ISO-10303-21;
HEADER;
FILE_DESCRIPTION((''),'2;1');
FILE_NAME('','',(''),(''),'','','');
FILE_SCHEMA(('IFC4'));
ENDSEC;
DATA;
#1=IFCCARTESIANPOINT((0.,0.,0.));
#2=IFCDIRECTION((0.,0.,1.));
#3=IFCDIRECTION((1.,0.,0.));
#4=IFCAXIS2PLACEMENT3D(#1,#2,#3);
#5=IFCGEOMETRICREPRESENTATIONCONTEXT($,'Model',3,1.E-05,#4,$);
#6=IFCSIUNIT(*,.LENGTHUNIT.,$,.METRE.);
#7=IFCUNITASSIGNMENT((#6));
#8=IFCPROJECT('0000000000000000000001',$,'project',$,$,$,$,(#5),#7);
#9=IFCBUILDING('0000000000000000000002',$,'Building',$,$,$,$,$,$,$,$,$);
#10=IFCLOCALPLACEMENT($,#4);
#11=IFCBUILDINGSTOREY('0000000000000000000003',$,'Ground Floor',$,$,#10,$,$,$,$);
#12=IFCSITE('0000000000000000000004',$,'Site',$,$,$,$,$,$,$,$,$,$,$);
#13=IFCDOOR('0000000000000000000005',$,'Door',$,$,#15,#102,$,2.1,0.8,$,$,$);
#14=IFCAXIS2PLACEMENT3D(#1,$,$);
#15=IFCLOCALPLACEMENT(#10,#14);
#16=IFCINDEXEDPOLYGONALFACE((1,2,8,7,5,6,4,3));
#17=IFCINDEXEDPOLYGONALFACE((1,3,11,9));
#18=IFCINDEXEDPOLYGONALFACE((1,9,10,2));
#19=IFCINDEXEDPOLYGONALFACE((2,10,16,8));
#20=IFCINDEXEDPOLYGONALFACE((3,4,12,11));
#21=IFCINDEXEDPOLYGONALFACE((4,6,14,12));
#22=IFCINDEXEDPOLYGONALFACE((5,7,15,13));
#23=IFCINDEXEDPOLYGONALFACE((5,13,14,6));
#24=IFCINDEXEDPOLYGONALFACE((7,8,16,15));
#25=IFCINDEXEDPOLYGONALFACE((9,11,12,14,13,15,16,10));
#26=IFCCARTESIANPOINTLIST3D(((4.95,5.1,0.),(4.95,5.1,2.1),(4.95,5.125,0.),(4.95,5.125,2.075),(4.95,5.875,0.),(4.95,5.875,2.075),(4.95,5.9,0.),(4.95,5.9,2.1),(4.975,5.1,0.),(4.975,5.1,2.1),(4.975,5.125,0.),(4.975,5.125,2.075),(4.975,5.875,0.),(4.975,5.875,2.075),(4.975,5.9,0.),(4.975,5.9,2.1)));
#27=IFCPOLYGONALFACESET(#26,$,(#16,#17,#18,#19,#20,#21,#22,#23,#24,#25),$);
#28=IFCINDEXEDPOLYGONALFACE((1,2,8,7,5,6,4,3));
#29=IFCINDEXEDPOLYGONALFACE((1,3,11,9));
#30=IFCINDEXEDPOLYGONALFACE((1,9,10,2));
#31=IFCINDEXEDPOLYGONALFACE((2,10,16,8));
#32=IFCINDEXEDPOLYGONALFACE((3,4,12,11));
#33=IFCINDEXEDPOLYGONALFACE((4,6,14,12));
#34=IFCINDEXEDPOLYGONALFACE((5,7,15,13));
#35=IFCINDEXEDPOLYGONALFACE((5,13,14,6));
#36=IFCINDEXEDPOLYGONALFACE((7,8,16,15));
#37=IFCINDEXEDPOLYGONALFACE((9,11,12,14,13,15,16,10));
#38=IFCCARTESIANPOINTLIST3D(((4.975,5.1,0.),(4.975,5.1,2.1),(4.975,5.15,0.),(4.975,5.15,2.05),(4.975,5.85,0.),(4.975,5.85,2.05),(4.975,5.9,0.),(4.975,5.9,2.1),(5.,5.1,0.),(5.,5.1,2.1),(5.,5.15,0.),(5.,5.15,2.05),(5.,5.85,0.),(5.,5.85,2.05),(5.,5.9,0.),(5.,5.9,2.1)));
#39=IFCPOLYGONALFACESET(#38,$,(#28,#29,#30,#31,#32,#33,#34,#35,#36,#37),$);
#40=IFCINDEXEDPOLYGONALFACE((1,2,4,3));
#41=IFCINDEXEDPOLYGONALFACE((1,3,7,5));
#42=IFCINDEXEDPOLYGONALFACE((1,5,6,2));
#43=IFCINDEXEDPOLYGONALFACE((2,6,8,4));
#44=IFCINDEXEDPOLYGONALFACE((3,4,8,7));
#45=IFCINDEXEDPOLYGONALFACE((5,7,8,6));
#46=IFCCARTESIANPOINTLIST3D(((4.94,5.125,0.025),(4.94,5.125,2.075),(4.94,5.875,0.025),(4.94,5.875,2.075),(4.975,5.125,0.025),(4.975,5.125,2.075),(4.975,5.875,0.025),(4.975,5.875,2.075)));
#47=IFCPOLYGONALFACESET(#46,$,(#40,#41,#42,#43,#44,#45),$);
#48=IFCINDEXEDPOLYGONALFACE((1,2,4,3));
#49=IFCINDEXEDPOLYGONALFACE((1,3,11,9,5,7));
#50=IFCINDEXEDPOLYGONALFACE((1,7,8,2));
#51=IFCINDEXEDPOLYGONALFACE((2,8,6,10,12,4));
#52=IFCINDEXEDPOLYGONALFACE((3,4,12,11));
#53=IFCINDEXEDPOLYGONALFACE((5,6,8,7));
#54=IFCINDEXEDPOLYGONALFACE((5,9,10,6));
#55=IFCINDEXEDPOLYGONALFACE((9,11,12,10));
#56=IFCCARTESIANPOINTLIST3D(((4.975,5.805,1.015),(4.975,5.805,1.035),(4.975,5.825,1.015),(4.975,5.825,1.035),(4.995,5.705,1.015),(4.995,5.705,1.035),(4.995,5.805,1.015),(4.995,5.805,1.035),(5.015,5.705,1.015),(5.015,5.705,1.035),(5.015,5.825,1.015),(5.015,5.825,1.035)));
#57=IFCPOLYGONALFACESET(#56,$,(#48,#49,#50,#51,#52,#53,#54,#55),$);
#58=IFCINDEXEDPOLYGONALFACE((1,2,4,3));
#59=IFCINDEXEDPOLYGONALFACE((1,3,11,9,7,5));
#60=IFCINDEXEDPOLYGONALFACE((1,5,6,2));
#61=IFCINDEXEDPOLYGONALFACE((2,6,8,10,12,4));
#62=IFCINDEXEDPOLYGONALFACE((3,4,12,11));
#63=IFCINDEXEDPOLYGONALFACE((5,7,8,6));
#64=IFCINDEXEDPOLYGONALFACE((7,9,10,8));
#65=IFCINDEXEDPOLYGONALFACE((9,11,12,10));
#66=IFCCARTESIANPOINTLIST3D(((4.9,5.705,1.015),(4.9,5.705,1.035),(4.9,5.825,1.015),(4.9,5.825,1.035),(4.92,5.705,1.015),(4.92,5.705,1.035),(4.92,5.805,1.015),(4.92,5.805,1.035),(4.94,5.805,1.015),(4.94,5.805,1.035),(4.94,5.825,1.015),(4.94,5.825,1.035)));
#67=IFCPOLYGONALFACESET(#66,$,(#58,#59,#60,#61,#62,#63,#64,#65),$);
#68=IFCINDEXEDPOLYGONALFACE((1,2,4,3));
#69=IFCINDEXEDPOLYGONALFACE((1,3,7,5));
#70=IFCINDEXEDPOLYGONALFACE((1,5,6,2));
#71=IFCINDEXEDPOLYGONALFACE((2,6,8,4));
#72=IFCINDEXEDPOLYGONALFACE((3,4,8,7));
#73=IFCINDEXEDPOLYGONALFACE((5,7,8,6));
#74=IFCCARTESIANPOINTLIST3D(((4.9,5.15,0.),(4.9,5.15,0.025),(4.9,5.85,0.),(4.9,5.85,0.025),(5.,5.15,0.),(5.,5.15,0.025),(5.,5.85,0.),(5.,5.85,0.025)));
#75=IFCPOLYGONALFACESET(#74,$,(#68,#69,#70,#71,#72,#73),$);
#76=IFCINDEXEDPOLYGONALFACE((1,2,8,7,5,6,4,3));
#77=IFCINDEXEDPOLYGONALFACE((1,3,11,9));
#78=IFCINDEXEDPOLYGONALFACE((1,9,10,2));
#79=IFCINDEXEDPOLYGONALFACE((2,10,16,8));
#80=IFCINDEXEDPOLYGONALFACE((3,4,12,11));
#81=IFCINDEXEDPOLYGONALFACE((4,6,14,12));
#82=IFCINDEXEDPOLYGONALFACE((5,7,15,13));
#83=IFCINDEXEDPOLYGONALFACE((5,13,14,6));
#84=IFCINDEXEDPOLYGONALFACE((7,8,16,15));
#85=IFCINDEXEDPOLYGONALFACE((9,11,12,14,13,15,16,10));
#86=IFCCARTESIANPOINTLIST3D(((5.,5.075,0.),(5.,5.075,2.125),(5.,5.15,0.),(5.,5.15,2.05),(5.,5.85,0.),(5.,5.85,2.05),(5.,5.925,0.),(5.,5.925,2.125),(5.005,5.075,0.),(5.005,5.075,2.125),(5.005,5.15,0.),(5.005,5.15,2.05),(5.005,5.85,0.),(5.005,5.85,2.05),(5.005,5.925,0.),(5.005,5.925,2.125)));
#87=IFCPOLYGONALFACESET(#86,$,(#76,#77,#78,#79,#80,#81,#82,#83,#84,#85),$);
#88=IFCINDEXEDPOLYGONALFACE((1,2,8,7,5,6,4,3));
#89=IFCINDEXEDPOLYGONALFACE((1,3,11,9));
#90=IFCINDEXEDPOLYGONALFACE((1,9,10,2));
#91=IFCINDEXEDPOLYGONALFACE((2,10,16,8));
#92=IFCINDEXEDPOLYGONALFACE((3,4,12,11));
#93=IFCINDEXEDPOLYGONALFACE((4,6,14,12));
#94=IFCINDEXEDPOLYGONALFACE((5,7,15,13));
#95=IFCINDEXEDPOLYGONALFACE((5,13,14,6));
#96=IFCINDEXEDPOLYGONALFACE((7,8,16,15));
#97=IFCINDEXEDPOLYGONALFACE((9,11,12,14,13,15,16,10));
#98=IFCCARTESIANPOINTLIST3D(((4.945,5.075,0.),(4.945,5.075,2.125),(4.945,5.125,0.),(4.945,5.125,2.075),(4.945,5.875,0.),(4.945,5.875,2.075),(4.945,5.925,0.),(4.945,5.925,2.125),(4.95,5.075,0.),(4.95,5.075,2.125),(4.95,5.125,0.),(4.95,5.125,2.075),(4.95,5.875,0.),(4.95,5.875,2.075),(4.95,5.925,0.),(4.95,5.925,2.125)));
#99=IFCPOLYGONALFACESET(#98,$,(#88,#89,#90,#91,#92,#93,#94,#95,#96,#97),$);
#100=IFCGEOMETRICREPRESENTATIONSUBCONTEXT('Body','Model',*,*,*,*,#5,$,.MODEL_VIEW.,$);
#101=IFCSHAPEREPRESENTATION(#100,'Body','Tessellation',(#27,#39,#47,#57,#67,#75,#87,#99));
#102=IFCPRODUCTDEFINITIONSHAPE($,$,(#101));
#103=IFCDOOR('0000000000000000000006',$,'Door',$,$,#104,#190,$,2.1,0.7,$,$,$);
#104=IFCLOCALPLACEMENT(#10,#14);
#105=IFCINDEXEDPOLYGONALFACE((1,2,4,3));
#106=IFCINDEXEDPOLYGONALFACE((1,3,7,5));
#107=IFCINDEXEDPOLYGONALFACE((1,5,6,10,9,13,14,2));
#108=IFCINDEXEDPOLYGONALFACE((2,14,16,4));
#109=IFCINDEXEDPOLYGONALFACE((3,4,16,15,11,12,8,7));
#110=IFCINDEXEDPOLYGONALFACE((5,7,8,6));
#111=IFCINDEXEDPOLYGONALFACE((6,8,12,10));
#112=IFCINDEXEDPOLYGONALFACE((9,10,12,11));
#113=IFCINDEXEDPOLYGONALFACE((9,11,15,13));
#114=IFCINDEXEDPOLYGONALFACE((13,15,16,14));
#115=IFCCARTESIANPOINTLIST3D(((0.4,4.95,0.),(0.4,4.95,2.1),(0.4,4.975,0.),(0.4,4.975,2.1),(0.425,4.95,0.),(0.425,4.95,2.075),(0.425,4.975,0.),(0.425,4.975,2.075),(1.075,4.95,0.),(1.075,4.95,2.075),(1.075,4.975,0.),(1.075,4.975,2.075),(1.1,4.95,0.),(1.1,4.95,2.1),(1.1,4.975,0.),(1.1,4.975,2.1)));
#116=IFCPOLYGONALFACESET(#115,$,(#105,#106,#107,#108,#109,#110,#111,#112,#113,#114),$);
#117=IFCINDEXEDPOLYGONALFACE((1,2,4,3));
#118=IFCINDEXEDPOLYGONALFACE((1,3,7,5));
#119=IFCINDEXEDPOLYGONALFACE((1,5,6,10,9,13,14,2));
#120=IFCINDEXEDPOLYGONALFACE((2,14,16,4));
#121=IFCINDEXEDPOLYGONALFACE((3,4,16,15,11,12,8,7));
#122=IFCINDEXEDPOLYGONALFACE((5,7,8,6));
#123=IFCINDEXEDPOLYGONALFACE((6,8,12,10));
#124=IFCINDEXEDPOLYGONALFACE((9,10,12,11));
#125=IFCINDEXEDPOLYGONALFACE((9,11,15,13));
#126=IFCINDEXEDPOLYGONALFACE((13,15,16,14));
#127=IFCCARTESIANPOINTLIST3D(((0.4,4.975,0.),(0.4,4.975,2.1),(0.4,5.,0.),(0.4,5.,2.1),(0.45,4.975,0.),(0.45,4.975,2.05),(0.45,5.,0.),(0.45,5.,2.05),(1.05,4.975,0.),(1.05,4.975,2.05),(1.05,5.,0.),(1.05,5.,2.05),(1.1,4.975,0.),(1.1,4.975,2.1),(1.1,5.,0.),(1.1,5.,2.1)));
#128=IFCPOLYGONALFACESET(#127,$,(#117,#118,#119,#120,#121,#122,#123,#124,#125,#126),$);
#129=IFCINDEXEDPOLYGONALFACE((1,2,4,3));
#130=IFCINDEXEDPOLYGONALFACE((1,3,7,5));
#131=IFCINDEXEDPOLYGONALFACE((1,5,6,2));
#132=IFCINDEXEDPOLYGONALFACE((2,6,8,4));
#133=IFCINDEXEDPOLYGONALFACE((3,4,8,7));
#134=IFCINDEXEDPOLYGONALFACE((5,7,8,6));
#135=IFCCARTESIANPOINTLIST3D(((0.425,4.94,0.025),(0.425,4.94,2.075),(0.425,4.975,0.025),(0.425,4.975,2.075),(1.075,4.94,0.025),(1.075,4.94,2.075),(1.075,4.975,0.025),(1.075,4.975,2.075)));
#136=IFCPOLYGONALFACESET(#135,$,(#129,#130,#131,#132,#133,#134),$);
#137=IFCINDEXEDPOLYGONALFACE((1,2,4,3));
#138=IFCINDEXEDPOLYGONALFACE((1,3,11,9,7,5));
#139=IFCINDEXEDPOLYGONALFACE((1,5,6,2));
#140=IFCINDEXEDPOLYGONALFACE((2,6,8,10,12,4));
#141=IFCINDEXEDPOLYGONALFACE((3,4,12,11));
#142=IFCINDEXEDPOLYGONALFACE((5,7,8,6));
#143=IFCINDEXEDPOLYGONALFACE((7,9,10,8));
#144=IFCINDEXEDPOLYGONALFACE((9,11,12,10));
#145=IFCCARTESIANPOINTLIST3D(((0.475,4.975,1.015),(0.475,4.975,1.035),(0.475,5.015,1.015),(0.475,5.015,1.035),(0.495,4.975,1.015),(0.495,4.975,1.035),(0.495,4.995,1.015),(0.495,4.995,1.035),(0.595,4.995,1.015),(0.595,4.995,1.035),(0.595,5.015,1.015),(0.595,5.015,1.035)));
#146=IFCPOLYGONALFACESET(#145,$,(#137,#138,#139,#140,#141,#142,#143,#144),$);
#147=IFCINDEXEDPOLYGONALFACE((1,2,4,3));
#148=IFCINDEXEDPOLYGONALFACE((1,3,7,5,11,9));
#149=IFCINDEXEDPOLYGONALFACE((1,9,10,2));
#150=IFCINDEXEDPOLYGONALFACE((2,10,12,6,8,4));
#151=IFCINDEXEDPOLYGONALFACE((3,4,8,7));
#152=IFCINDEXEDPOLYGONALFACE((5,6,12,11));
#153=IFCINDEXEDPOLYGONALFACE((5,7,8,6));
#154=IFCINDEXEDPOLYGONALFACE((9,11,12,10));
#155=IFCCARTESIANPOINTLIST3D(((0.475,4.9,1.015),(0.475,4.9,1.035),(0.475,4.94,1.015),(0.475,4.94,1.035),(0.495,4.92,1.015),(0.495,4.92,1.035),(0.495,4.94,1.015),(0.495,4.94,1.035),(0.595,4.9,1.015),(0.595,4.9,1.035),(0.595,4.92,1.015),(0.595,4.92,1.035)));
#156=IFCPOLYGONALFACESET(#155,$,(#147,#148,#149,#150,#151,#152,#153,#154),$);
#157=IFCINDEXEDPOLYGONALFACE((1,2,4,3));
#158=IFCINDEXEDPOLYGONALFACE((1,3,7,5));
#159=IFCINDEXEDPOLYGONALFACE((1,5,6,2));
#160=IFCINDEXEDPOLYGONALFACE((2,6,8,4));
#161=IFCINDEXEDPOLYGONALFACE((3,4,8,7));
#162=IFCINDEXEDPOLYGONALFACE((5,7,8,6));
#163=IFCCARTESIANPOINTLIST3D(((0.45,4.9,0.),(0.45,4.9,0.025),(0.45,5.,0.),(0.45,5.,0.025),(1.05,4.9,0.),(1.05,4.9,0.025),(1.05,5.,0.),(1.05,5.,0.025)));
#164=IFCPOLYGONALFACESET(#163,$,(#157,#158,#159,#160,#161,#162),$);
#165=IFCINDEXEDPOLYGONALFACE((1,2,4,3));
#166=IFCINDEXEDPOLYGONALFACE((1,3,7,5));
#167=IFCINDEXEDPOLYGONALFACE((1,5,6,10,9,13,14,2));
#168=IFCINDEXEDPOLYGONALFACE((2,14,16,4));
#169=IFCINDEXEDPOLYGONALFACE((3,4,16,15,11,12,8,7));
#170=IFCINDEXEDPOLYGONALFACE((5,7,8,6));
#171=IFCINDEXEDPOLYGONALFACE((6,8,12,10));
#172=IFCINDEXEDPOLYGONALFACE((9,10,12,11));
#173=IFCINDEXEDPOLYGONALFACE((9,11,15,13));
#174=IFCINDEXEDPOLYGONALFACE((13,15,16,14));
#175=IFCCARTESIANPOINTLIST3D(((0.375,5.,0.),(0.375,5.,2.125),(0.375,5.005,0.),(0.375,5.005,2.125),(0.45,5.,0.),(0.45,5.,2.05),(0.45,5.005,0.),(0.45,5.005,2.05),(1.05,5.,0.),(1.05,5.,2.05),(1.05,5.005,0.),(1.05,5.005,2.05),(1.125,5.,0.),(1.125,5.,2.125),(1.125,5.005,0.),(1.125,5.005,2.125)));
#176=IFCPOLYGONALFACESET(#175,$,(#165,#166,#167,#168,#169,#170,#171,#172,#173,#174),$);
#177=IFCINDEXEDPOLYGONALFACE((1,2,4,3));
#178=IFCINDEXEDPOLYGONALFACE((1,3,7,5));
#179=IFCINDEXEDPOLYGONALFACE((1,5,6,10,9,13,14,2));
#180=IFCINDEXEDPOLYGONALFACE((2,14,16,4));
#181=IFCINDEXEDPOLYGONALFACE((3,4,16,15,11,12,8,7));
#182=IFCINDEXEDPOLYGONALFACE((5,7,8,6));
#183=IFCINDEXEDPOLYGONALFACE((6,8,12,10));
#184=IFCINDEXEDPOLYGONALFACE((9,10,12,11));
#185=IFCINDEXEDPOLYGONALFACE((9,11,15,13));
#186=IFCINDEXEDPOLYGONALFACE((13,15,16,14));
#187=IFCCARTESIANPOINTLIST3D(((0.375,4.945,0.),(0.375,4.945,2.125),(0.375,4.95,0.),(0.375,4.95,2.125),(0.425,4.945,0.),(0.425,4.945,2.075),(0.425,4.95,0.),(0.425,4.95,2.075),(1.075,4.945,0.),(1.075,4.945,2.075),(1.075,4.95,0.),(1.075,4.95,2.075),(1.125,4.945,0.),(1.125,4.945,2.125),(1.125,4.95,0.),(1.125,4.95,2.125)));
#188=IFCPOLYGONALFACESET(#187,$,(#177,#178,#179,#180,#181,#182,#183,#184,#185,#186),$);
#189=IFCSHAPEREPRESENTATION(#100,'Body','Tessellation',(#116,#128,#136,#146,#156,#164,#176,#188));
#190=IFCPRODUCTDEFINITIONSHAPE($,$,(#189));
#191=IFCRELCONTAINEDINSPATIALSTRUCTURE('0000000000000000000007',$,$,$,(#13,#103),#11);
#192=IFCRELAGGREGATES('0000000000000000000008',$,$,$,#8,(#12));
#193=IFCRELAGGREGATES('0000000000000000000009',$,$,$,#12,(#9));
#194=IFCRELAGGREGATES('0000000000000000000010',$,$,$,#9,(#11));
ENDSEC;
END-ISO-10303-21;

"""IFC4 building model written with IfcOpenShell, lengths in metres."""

from ifc_helpers import new_model, si_unit, frame, origin_with_axes, place, context, subcontext, project, spatial, line, indexed_curve, outline, extrude, element, save


model = new_model("IFC4")

# Units and contexts
model_context = context("Model", 3, precision=1e-05, world=origin_with_axes())
body_context = subcontext(model_context, "Body", "Model", "MODEL_VIEW")
ifc_project = project(units=[si_unit("LENGTHUNIT", "METRE")], contexts=[model_context])

# Site, building, storey
site = spatial("IfcSite", under=ifc_project, Name="Site")
building = spatial("IfcBuilding", under=site, Name="Building")
storey_placement = place(None, origin_with_axes())
storey = spatial("IfcBuildingStorey", under=building, at=storey_placement, Name="Ground Floor")

# Doors
door_1_placement = place(storey_placement, frame((5.0, 5.1, 0.0), z_axis=(0.0, 0.0, 1.0), x_axis=(0.0, 1.0, 0.0)))
element("IfcDoor", 1, at=door_1_placement, inside=storey, Name="Door", OverallHeight=2.1, OverallWidth=0.8, context=body_context, shape_type="SweptSolid", body=[
    extrude(outline(indexed_curve([(0.0, 0.0), (0.0, 2.1), (0.8, 2.1), (0.8, 0.0), (0.775, 0.0), (0.775, 2.075), (0.025, 2.075), (0.025, 0.0)], segments=[line(1, 2, 3, 4, 5, 6, 7, 8, 1)])), frame((0.0, 0.025, 0.0), z_axis=(0.0, -1.0, 0.0), x_axis=(1.0, 0.0, 0.0)), (0.0, 0.0, -1.0), 0.025),
    extrude(outline(indexed_curve([(0.0, 0.0), (0.0, 2.1), (0.8, 2.1), (0.8, 0.0), (0.75, 0.0), (0.75, 2.05), (0.05, 2.05), (0.05, 0.0)], segments=[line(1, 2, 3, 4, 5, 6, 7, 8, 1)])), frame((0.0, 0.0, 0.0), z_axis=(0.0, -1.0, 0.0), x_axis=(1.0, 0.0, 0.0)), (0.0, 0.0, -1.0), 0.025),
    extrude(outline(indexed_curve([(0.0, 0.0), (0.75, 0.0), (0.75, 0.035), (0.0, 0.035)], segments=[line(1, 2, 3, 4, 1)])), frame((0.025, 0.025, 0.025), z_axis=(0.0, 0.0, 1.0), x_axis=(1.0, 0.0, 0.0)), (0.0, 0.0, 1.0), 2.05),
    extrude(outline(indexed_curve([(0.0, 0.0), (0.0, -0.04), (-0.12, -0.04), (-0.12, -0.02), (-0.02, -0.02), (-0.02, 0.0)], segments=[line(1, 2, 3, 4, 5, 6, 1)])), frame((0.725, 0.025, 1.015), z_axis=(0.0, 0.0, 1.0), x_axis=(1.0, 0.0, 0.0)), (0.0, 0.0, 1.0), 0.02),
    extrude(outline(indexed_curve([(0.0, 0.0), (0.0, 0.04), (-0.12, 0.04), (-0.12, 0.02), (-0.02, 0.02), (-0.02, 0.0)], segments=[line(1, 2, 3, 4, 5, 6, 1)])), frame((0.725, 0.06, 1.015), z_axis=(0.0, 0.0, 1.0), x_axis=(1.0, 0.0, 0.0)), (0.0, 0.0, 1.0), 0.02),
    extrude(outline(indexed_curve([(0.0, 0.0), (0.7, 0.0), (0.7, 0.1), (0.0, 0.1)], segments=[line(1, 2, 3, 4, 1)])), frame((0.05, 0.0, 0.0), z_axis=(0.0, 0.0, 1.0), x_axis=(1.0, 0.0, 0.0)), (0.0, 0.0, 1.0), 0.025),
    extrude(outline(indexed_curve([(0.0, 0.0), (0.0, 2.125), (0.85, 2.125), (0.85, 0.0), (0.775, 0.0), (0.775, 2.05), (0.075, 2.05), (0.075, 0.0)], segments=[line(1, 2, 3, 4, 5, 6, 7, 8, 1)])), frame((-0.025, -0.005, 0.0), z_axis=(0.0, -1.0, 0.0), x_axis=(1.0, 0.0, 0.0)), (0.0, 0.0, -1.0), 0.005),
    extrude(outline(indexed_curve([(0.0, 0.0), (0.0, 2.125), (0.85, 2.125), (0.85, 0.0), (0.8, 0.0), (0.8, 2.075), (0.05, 2.075), (0.05, 0.0)], segments=[line(1, 2, 3, 4, 5, 6, 7, 8, 1)])), frame((-0.025, 0.05, 0.0), z_axis=(0.0, -1.0, 0.0), x_axis=(1.0, 0.0, 0.0)), (0.0, 0.0, -1.0), 0.005),
])
door_2_placement = place(storey_placement, frame((1.1, 5.0, 0.0), z_axis=(0.0, 0.0, 1.0), x_axis=(-1.0, 0.0, 0.0)))
element("IfcDoor", 2, at=door_2_placement, inside=storey, Name="Door", OverallHeight=2.1, OverallWidth=0.7, context=body_context, shape_type="SweptSolid", body=[
    extrude(outline(indexed_curve([(0.0, 0.0), (0.0, 2.1), (0.7, 2.1), (0.7, 0.0), (0.675, 0.0), (0.675, 2.075), (0.025, 2.075), (0.025, 0.0)], segments=[line(1, 2, 3, 4, 5, 6, 7, 8, 1)])), frame((0.0, 0.025, 0.0), z_axis=(0.0, -1.0, 0.0), x_axis=(1.0, 0.0, 0.0)), (0.0, 0.0, -1.0), 0.025),
    extrude(outline(indexed_curve([(0.0, 0.0), (0.0, 2.1), (0.7, 2.1), (0.7, 0.0), (0.65, 0.0), (0.65, 2.05), (0.05, 2.05), (0.05, 0.0)], segments=[line(1, 2, 3, 4, 5, 6, 7, 8, 1)])), frame((0.0, 0.0, 0.0), z_axis=(0.0, -1.0, 0.0), x_axis=(1.0, 0.0, 0.0)), (0.0, 0.0, -1.0), 0.025),
    extrude(outline(indexed_curve([(0.0, 0.0), (0.65, 0.0), (0.65, 0.035), (0.0, 0.035)], segments=[line(1, 2, 3, 4, 1)])), frame((0.025, 0.025, 0.025), z_axis=(0.0, 0.0, 1.0), x_axis=(1.0, 0.0, 0.0)), (0.0, 0.0, 1.0), 2.05),
    extrude(outline(indexed_curve([(0.0, 0.0), (0.0, -0.04), (-0.12, -0.04), (-0.12, -0.02), (-0.02, -0.02), (-0.02, 0.0)], segments=[line(1, 2, 3, 4, 5, 6, 1)])), frame((0.625, 0.025, 1.015), z_axis=(0.0, 0.0, 1.0), x_axis=(1.0, 0.0, 0.0)), (0.0, 0.0, 1.0), 0.02),
    extrude(outline(indexed_curve([(0.0, 0.0), (0.0, 0.04), (-0.12, 0.04), (-0.12, 0.02), (-0.02, 0.02), (-0.02, 0.0)], segments=[line(1, 2, 3, 4, 5, 6, 1)])), frame((0.625, 0.06, 1.015), z_axis=(0.0, 0.0, 1.0), x_axis=(1.0, 0.0, 0.0)), (0.0, 0.0, 1.0), 0.02),
    extrude(outline(indexed_curve([(0.0, 0.0), (0.6, 0.0), (0.6, 0.1), (0.0, 0.1)], segments=[line(1, 2, 3, 4, 1)])), frame((0.05, 0.0, 0.0), z_axis=(0.0, 0.0, 1.0), x_axis=(1.0, 0.0, 0.0)), (0.0, 0.0, 1.0), 0.025),
    extrude(outline(indexed_curve([(0.0, 0.0), (0.0, 2.125), (0.75, 2.125), (0.75, 0.0), (0.675, 0.0), (0.675, 2.05), (0.075, 2.05), (0.075, 0.0)], segments=[line(1, 2, 3, 4, 5, 6, 7, 8, 1)])), frame((-0.025, -0.005, 0.0), z_axis=(0.0, -1.0, 0.0), x_axis=(1.0, 0.0, 0.0)), (0.0, 0.0, -1.0), 0.005),
    extrude(outline(indexed_curve([(0.0, 0.0), (0.0, 2.125), (0.75, 2.125), (0.75, 0.0), (0.7, 0.0), (0.7, 2.075), (0.05, 2.075), (0.05, 0.0)], segments=[line(1, 2, 3, 4, 5, 6, 7, 8, 1)])), frame((-0.025, 0.05, 0.0), z_axis=(0.0, -1.0, 0.0), x_axis=(1.0, 0.0, 0.0)), (0.0, 0.0, -1.0), 0.005),
])

save(model, "model.ifc")
